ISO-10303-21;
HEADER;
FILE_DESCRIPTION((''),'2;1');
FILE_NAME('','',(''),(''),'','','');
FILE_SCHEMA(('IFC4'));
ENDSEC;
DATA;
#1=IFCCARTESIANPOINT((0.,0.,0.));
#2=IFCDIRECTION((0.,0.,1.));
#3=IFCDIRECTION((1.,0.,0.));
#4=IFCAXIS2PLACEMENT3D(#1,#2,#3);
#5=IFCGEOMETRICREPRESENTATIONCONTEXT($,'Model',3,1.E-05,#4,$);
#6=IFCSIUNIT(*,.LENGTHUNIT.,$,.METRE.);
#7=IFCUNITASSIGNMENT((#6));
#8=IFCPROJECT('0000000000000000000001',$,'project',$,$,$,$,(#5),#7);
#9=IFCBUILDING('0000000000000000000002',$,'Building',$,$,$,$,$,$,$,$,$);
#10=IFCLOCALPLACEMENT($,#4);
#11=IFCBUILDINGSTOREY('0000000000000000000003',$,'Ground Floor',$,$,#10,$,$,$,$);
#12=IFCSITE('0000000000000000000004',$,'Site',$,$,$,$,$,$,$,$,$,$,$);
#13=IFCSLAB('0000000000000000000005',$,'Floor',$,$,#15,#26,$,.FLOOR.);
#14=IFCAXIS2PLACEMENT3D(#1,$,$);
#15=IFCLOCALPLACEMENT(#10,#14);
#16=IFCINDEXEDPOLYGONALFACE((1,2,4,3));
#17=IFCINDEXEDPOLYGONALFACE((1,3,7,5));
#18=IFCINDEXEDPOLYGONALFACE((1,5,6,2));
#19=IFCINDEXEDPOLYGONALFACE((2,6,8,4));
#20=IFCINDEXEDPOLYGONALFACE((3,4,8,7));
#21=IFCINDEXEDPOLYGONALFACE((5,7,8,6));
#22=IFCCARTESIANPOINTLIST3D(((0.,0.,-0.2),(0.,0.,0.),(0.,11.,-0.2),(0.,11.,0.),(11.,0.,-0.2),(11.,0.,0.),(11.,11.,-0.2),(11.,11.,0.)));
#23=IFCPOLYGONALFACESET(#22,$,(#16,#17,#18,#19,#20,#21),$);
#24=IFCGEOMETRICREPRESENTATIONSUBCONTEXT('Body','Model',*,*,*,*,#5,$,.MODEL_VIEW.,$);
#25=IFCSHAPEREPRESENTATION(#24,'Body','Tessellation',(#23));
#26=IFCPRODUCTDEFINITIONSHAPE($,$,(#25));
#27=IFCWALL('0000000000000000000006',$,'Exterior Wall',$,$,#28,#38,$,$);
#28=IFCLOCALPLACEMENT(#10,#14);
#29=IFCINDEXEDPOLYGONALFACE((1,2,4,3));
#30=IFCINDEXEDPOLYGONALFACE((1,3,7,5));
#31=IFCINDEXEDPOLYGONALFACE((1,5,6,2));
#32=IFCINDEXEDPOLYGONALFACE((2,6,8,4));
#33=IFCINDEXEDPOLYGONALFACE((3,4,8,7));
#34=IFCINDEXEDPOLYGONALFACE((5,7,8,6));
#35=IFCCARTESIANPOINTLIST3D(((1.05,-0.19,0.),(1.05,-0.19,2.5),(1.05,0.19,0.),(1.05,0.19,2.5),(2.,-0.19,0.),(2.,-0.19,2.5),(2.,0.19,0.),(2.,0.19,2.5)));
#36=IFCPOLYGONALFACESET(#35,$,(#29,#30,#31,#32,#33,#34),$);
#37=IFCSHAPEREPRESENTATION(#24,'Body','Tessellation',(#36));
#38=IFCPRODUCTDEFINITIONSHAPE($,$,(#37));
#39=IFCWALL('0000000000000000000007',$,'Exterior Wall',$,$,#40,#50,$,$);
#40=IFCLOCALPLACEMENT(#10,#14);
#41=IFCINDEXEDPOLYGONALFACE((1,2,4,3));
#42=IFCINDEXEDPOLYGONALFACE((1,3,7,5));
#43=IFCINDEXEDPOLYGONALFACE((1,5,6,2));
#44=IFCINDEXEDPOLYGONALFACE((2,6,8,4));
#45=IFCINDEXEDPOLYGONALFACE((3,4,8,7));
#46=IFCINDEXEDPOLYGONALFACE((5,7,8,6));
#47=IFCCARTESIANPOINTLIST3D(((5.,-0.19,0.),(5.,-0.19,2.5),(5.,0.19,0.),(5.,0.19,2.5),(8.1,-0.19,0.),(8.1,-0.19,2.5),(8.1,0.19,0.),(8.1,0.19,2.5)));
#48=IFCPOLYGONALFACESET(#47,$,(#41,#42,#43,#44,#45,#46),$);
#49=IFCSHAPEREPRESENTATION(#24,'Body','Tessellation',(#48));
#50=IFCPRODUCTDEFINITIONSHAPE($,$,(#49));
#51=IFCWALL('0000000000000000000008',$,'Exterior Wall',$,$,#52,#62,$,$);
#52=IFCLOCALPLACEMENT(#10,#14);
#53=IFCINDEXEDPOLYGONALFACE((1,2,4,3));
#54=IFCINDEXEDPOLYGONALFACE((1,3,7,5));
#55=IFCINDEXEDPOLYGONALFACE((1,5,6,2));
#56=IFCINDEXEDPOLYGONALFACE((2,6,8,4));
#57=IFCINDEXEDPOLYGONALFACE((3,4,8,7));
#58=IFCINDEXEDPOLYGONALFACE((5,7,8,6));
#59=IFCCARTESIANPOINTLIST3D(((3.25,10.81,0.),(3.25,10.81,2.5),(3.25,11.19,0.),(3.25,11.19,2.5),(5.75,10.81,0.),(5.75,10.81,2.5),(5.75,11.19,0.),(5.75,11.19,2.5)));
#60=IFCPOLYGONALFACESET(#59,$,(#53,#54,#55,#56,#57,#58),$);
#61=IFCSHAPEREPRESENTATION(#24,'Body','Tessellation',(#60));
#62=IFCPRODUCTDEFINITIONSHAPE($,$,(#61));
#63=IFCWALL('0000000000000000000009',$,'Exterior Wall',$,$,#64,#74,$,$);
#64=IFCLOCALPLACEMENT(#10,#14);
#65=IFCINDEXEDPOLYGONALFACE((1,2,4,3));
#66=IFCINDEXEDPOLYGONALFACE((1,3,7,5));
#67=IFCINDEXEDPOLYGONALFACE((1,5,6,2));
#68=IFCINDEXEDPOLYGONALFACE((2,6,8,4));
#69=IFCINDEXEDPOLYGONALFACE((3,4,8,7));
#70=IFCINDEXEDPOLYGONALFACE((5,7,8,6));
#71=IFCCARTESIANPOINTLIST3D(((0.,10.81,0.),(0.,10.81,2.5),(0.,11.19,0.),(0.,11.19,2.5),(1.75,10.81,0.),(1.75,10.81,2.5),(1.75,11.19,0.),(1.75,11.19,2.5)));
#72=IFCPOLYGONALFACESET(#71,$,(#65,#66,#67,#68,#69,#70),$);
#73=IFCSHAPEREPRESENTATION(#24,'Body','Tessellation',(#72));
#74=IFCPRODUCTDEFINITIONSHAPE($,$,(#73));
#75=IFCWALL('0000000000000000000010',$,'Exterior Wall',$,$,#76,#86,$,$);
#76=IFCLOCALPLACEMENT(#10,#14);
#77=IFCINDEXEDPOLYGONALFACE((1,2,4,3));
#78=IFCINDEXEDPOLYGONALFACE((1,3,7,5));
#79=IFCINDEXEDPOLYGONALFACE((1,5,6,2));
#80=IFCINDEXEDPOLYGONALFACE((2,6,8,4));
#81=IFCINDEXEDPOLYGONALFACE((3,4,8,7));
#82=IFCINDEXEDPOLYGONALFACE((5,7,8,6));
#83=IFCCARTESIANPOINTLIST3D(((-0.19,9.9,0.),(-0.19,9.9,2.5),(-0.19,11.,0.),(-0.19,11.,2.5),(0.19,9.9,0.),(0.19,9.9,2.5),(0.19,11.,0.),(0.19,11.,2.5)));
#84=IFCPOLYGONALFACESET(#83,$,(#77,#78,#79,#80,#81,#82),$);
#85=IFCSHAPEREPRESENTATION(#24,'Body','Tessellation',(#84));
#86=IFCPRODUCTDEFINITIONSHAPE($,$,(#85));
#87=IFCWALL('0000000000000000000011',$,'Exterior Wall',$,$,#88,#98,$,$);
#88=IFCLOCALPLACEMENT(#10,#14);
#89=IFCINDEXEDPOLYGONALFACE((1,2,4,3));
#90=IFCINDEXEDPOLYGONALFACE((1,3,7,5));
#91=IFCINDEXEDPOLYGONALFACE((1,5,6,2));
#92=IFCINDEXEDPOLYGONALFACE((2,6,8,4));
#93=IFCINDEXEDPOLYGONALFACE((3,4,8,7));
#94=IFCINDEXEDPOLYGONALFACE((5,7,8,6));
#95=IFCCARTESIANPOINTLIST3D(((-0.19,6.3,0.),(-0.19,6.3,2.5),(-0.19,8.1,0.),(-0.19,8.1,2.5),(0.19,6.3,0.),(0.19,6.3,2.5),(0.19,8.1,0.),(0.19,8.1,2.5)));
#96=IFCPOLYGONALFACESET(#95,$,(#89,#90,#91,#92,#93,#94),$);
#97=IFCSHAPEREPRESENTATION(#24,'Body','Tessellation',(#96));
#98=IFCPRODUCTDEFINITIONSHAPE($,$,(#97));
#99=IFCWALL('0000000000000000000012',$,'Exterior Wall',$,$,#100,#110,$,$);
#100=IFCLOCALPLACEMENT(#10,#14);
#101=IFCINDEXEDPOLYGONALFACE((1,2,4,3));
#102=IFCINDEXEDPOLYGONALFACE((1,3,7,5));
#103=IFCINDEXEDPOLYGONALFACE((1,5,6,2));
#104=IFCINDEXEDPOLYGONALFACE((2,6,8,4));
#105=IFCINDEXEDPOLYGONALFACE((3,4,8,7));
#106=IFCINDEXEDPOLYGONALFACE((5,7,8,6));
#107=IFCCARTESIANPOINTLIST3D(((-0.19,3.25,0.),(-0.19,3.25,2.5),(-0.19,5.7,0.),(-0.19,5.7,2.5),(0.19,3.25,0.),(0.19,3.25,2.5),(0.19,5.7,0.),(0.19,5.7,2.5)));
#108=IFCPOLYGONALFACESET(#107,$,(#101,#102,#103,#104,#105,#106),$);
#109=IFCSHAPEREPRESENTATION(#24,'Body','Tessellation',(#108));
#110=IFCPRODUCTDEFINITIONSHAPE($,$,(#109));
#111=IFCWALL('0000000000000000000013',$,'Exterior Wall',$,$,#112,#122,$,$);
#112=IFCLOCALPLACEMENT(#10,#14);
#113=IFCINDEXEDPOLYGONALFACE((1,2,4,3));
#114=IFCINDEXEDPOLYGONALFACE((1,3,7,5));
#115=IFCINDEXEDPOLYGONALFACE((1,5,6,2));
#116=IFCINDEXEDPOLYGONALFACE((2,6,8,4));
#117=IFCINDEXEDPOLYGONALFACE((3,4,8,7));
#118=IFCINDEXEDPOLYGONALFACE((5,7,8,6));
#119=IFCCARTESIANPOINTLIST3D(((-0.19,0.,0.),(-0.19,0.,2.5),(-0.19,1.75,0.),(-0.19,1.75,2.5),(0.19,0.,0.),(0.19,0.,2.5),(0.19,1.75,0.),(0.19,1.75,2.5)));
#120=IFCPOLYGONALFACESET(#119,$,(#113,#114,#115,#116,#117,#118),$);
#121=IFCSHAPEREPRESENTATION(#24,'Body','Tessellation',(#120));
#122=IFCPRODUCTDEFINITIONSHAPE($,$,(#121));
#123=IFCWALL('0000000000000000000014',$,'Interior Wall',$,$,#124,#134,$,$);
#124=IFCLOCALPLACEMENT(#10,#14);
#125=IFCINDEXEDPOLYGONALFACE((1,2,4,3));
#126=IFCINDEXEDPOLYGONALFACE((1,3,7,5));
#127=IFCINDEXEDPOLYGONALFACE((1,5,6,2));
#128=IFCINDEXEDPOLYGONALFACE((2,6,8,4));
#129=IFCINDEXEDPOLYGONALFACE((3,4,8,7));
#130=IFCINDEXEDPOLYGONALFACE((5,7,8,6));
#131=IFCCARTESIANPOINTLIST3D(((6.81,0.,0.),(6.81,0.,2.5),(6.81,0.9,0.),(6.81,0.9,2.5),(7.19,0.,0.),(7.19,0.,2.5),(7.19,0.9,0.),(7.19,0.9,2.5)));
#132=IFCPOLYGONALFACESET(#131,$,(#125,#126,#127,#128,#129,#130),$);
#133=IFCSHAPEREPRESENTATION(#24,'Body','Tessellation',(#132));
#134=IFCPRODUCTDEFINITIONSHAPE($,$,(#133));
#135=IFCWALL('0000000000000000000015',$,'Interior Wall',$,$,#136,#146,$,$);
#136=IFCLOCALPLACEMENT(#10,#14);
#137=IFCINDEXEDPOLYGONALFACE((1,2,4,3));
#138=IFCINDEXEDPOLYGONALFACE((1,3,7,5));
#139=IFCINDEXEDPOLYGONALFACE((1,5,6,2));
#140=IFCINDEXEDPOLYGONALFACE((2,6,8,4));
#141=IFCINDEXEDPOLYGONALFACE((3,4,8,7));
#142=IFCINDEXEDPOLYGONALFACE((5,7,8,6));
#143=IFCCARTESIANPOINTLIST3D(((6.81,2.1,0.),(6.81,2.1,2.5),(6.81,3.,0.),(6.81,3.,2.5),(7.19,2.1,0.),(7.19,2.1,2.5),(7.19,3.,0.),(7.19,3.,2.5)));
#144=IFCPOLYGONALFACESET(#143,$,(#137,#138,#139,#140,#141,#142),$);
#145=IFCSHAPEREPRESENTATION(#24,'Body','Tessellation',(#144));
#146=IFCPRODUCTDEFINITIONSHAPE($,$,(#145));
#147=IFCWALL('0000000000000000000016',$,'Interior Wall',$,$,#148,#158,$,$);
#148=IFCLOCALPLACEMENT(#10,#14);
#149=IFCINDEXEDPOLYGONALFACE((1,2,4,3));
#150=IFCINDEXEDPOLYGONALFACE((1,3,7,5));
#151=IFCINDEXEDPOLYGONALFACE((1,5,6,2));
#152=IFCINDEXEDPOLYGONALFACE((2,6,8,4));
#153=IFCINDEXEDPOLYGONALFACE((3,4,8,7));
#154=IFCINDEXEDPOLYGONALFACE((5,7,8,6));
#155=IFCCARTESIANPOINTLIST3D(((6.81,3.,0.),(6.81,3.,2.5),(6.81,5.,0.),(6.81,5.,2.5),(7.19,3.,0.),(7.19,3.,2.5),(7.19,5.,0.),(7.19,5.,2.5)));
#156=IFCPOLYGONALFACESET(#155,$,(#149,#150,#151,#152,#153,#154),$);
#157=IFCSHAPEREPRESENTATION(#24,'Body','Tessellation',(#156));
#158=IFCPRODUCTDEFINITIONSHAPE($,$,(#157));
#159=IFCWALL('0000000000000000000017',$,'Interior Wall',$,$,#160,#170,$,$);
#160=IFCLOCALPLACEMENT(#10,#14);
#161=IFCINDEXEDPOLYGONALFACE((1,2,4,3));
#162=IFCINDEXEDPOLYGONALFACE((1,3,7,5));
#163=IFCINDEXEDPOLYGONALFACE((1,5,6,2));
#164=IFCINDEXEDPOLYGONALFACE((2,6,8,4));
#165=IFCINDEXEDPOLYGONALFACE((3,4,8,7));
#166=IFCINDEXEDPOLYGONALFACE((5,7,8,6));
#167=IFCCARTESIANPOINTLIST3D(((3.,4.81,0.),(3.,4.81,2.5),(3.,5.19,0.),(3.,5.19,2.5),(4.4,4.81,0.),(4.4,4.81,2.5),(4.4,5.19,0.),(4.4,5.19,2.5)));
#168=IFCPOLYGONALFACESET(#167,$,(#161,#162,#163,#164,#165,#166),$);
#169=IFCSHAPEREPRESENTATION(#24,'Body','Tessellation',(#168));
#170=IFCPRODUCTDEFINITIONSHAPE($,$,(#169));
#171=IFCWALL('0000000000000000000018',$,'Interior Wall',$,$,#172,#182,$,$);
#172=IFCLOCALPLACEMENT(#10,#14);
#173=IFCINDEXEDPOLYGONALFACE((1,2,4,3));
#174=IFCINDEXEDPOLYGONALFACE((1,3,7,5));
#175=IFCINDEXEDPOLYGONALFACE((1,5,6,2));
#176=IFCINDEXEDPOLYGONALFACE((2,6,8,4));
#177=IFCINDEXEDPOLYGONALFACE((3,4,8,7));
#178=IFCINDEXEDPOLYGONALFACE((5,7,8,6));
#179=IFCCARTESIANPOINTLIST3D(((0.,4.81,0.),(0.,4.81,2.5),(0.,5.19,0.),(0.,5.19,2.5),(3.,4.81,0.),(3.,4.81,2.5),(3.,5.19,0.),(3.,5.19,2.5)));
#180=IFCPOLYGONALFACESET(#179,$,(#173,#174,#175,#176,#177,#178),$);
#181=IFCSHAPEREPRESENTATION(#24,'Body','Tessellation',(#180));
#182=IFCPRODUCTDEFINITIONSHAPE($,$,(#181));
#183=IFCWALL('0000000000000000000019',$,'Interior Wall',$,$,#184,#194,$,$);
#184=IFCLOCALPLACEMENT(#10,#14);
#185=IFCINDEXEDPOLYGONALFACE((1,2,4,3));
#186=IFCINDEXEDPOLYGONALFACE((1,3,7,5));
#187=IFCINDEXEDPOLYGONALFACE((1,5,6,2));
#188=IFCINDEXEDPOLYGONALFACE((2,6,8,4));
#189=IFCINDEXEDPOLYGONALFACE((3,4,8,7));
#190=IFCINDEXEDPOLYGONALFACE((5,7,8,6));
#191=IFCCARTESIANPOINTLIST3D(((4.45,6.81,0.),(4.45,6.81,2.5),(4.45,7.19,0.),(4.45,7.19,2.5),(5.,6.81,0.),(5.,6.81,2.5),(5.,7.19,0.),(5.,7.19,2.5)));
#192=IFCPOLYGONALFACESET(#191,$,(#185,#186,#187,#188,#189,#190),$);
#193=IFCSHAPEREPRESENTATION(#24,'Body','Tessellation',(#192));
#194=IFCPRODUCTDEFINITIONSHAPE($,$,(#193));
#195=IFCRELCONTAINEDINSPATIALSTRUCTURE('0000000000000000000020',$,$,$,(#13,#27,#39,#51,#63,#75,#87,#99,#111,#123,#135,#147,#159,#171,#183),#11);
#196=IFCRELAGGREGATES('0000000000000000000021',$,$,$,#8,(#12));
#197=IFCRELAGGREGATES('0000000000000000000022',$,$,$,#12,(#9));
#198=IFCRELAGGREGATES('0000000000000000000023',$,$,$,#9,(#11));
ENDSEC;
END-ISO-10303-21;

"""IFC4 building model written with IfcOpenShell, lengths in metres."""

from ifc_helpers import new_model, si_unit, frame, origin_with_axes, place, context, subcontext, project, spatial, indexed_curve, outline, extrude, element, save


model = new_model("IFC4")

# Units and contexts
model_context = context("Model", 3, precision=1e-05, world=origin_with_axes())
body_context = subcontext(model_context, "Body", "Model", "MODEL_VIEW")
ifc_project = project(units=[si_unit("LENGTHUNIT", "METRE")], contexts=[model_context])

# Site, building, storey
site = spatial("IfcSite", under=ifc_project, Name="Site")
building = spatial("IfcBuilding", under=site, Name="Building")
storey_placement = place(None, origin_with_axes())
storey = spatial("IfcBuildingStorey", under=building, at=storey_placement, Name="Ground Floor")

# Slab
slab_placement = place(storey_placement, frame((0.0, 0.0, -0.2), z_axis=(0.0, 0.0, 1.0), x_axis=(1.0, 0.0, 0.0)))
element("IfcSlab", 1, at=slab_placement, inside=storey, Name="Floor", PredefinedType="FLOOR", context=body_context, shape_type="SweptSolid", body=[
    extrude(outline(indexed_curve([(0.0, 0.0), (11.0, 0.0), (11.0, 11.0), (0.0, 11.0)])), None, (0.0, 0.0, 1.0), 0.2),
])

# Walls
wall_1_placement = place(storey_placement, frame((1.05, 0.0, 0.0), z_axis=(0.0, 0.0, 1.0), x_axis=(1.0, 0.0, 0.0)))
element("IfcWall", 2, at=wall_1_placement, inside=storey, Name="Exterior Wall", context=body_context, shape_type="SweptSolid", body=[
    extrude(outline(indexed_curve([(0.0, 0.0), (0.0, 0.38), (0.95, 0.38), (0.95, 0.0), (0.0, 0.0)], self_intersect=False)), frame((0.0, -0.19, 0.0), z_axis=(0.0, 0.0, 1.0), x_axis=(1.0, 0.0, 0.0)), (0.0, 0.0, 1.0), 2.5),
])
wall_2_placement = place(storey_placement, frame((5.0, 0.0, 0.0), z_axis=(0.0, 0.0, 1.0), x_axis=(1.0, 0.0, 0.0)))
element("IfcWall", 3, at=wall_2_placement, inside=storey, Name="Exterior Wall", context=body_context, shape_type="SweptSolid", body=[
    extrude(outline(indexed_curve([(0.0, 0.0), (0.0, 0.38), (3.1, 0.38), (3.1, 0.0), (0.0, 0.0)], self_intersect=False)), frame((0.0, -0.19, 0.0), z_axis=(0.0, 0.0, 1.0), x_axis=(1.0, 0.0, 0.0)), (0.0, 0.0, 1.0), 2.5),
])
wall_3_placement = place(storey_placement, frame((5.75, 11.0, 0.0), z_axis=(0.0, 0.0, 1.0), x_axis=(-1.0, 0.0, 0.0)))
element("IfcWall", 4, at=wall_3_placement, inside=storey, Name="Exterior Wall", context=body_context, shape_type="SweptSolid", body=[
    extrude(outline(indexed_curve([(0.0, 0.0), (0.0, 0.38), (2.5, 0.38), (2.5, 0.0), (0.0, 0.0)], self_intersect=False)), frame((0.0, -0.19, 0.0), z_axis=(0.0, 0.0, 1.0), x_axis=(1.0, 0.0, 0.0)), (0.0, 0.0, 1.0), 2.5),
])
wall_4_placement = place(storey_placement, frame((1.75, 11.0, 0.0), z_axis=(0.0, 0.0, 1.0), x_axis=(-1.0, 0.0, 0.0)))
element("IfcWall", 5, at=wall_4_placement, inside=storey, Name="Exterior Wall", context=body_context, shape_type="SweptSolid", body=[
    extrude(outline(indexed_curve([(0.0, 0.0), (0.0, 0.38), (1.75, 0.38), (1.75, 0.0), (0.0, 0.0)], self_intersect=False)), frame((0.0, -0.19, 0.0), z_axis=(0.0, 0.0, 1.0), x_axis=(1.0, 0.0, 0.0)), (0.0, 0.0, 1.0), 2.5),
])
wall_5_placement = place(storey_placement, frame((0.0, 11.0, 0.0), z_axis=(0.0, 0.0, 1.0), x_axis=(0.0, -1.0, 0.0)))
element("IfcWall", 6, at=wall_5_placement, inside=storey, Name="Exterior Wall", context=body_context, shape_type="SweptSolid", body=[
    extrude(outline(indexed_curve([(0.0, 0.0), (0.0, 0.38), (1.1, 0.38), (1.1, 0.0), (0.0, 0.0)], self_intersect=False)), frame((0.0, -0.19, 0.0), z_axis=(0.0, 0.0, 1.0), x_axis=(1.0, 0.0, 0.0)), (0.0, 0.0, 1.0), 2.5),
])
wall_6_placement = place(storey_placement, frame((0.0, 8.1, 0.0), z_axis=(0.0, 0.0, 1.0), x_axis=(0.0, -1.0, 0.0)))
element("IfcWall", 7, at=wall_6_placement, inside=storey, Name="Exterior Wall", context=body_context, shape_type="SweptSolid", body=[
    extrude(outline(indexed_curve([(0.0, 0.0), (0.0, 0.38), (1.8, 0.38), (1.8, 0.0), (0.0, 0.0)], self_intersect=False)), frame((0.0, -0.19, 0.0), z_axis=(0.0, 0.0, 1.0), x_axis=(1.0, 0.0, 0.0)), (0.0, 0.0, 1.0), 2.5),
])
wall_7_placement = place(storey_placement, frame((0.0, 5.7, 0.0), z_axis=(0.0, 0.0, 1.0), x_axis=(0.0, -1.0, 0.0)))
element("IfcWall", 8, at=wall_7_placement, inside=storey, Name="Exterior Wall", context=body_context, shape_type="SweptSolid", body=[
    extrude(outline(indexed_curve([(0.0, 0.0), (0.0, 0.38), (2.45, 0.38), (2.45, 0.0), (0.0, 0.0)], self_intersect=False)), frame((0.0, -0.19, 0.0), z_axis=(0.0, 0.0, 1.0), x_axis=(1.0, 0.0, 0.0)), (0.0, 0.0, 1.0), 2.5),
])
wall_8_placement = place(storey_placement, frame((0.0, 1.75, 0.0), z_axis=(0.0, 0.0, 1.0), x_axis=(0.0, -1.0, 0.0)))
element("IfcWall", 9, at=wall_8_placement, inside=storey, Name="Exterior Wall", context=body_context, shape_type="SweptSolid", body=[
    extrude(outline(indexed_curve([(0.0, 0.0), (0.0, 0.38), (1.75, 0.38), (1.75, 0.0), (0.0, 0.0)], self_intersect=False)), frame((0.0, -0.19, 0.0), z_axis=(0.0, 0.0, 1.0), x_axis=(1.0, 0.0, 0.0)), (0.0, 0.0, 1.0), 2.5),
])
wall_9_placement = place(storey_placement, frame((7.0, 0.0, 0.0), z_axis=(0.0, 0.0, 1.0), x_axis=(0.0, 1.0, 0.0)))
element("IfcWall", 10, at=wall_9_placement, inside=storey, Name="Interior Wall", context=body_context, shape_type="SweptSolid", body=[
    extrude(outline(indexed_curve([(0.0, 0.0), (0.0, 0.38), (0.9, 0.38), (0.9, 0.0), (0.0, 0.0)], self_intersect=False)), frame((0.0, -0.19, 0.0), z_axis=(0.0, 0.0, 1.0), x_axis=(1.0, 0.0, 0.0)), (0.0, 0.0, 1.0), 2.5),
])
wall_10_placement = place(storey_placement, frame((7.0, 2.1, 0.0), z_axis=(0.0, 0.0, 1.0), x_axis=(0.0, 1.0, 0.0)))
element("IfcWall", 11, at=wall_10_placement, inside=storey, Name="Interior Wall", context=body_context, shape_type="SweptSolid", body=[
    extrude(outline(indexed_curve([(0.0, 0.0), (0.0, 0.38), (0.9, 0.38), (0.9, 0.0), (0.0, 0.0)], self_intersect=False)), frame((0.0, -0.19, 0.0), z_axis=(0.0, 0.0, 1.0), x_axis=(1.0, 0.0, 0.0)), (0.0, 0.0, 1.0), 2.5),
])
wall_11_placement = place(storey_placement, frame((7.0, 3.0, 0.0), z_axis=(0.0, 0.0, 1.0), x_axis=(0.0, 1.0, 0.0)))
element("IfcWall", 12, at=wall_11_placement, inside=storey, Name="Interior Wall", context=body_context, shape_type="SweptSolid", body=[
    extrude(outline(indexed_curve([(0.0, 0.0), (0.0, 0.38), (2.0, 0.38), (2.0, 0.0), (0.0, 0.0)], self_intersect=False)), frame((0.0, -0.19, 0.0), z_axis=(0.0, 0.0, 1.0), x_axis=(1.0, 0.0, 0.0)), (0.0, 0.0, 1.0), 2.5),
])
wall_12_placement = place(storey_placement, frame((4.4, 5.0, 0.0), z_axis=(0.0, 0.0, 1.0), x_axis=(-1.0, 0.0, 0.0)))
element("IfcWall", 13, at=wall_12_placement, inside=storey, Name="Interior Wall", context=body_context, shape_type="SweptSolid", body=[
    extrude(outline(indexed_curve([(0.0, 0.0), (0.0, 0.38), (1.4, 0.38), (1.4, 0.0), (0.0, 0.0)], self_intersect=False)), frame((0.0, -0.19, 0.0), z_axis=(0.0, 0.0, 1.0), x_axis=(1.0, 0.0, 0.0)), (0.0, 0.0, 1.0), 2.5),
])
wall_13_placement = place(storey_placement, frame((3.0, 5.0, 0.0), z_axis=(0.0, 0.0, 1.0), x_axis=(-1.0, 0.0, 0.0)))
element("IfcWall", 14, at=wall_13_placement, inside=storey, Name="Interior Wall", context=body_context, shape_type="SweptSolid", body=[
    extrude(outline(indexed_curve([(0.0, 0.0), (0.0, 0.38), (3.0, 0.38), (3.0, 0.0), (0.0, 0.0)], self_intersect=False)), frame((0.0, -0.19, 0.0), z_axis=(0.0, 0.0, 1.0), x_axis=(1.0, 0.0, 0.0)), (0.0, 0.0, 1.0), 2.5),
])
for number, where, z_axis, x_axis, name in (
    (15, (5.0, 7.0, 0.0), (0.0, 0.0, 1.0), (-1.0, 0.0, 0.0), "Interior Wall"),
):
    element("IfcWall", number, at=place(storey_placement, frame(where, z_axis=z_axis, x_axis=x_axis)), inside=storey, Name=name, context=body_context, shape_type="SweptSolid", body=[
        extrude(outline(indexed_curve([(0.0, 0.0), (0.0, 0.38), (0.55, 0.38), (0.55, 0.0), (0.0, 0.0)], self_intersect=False)), frame((0.0, -0.19, 0.0), z_axis=(0.0, 0.0, 1.0), x_axis=(1.0, 0.0, 0.0)), (0.0, 0.0, 1.0), 2.5),
    ])

save(model, "model.ifc")
